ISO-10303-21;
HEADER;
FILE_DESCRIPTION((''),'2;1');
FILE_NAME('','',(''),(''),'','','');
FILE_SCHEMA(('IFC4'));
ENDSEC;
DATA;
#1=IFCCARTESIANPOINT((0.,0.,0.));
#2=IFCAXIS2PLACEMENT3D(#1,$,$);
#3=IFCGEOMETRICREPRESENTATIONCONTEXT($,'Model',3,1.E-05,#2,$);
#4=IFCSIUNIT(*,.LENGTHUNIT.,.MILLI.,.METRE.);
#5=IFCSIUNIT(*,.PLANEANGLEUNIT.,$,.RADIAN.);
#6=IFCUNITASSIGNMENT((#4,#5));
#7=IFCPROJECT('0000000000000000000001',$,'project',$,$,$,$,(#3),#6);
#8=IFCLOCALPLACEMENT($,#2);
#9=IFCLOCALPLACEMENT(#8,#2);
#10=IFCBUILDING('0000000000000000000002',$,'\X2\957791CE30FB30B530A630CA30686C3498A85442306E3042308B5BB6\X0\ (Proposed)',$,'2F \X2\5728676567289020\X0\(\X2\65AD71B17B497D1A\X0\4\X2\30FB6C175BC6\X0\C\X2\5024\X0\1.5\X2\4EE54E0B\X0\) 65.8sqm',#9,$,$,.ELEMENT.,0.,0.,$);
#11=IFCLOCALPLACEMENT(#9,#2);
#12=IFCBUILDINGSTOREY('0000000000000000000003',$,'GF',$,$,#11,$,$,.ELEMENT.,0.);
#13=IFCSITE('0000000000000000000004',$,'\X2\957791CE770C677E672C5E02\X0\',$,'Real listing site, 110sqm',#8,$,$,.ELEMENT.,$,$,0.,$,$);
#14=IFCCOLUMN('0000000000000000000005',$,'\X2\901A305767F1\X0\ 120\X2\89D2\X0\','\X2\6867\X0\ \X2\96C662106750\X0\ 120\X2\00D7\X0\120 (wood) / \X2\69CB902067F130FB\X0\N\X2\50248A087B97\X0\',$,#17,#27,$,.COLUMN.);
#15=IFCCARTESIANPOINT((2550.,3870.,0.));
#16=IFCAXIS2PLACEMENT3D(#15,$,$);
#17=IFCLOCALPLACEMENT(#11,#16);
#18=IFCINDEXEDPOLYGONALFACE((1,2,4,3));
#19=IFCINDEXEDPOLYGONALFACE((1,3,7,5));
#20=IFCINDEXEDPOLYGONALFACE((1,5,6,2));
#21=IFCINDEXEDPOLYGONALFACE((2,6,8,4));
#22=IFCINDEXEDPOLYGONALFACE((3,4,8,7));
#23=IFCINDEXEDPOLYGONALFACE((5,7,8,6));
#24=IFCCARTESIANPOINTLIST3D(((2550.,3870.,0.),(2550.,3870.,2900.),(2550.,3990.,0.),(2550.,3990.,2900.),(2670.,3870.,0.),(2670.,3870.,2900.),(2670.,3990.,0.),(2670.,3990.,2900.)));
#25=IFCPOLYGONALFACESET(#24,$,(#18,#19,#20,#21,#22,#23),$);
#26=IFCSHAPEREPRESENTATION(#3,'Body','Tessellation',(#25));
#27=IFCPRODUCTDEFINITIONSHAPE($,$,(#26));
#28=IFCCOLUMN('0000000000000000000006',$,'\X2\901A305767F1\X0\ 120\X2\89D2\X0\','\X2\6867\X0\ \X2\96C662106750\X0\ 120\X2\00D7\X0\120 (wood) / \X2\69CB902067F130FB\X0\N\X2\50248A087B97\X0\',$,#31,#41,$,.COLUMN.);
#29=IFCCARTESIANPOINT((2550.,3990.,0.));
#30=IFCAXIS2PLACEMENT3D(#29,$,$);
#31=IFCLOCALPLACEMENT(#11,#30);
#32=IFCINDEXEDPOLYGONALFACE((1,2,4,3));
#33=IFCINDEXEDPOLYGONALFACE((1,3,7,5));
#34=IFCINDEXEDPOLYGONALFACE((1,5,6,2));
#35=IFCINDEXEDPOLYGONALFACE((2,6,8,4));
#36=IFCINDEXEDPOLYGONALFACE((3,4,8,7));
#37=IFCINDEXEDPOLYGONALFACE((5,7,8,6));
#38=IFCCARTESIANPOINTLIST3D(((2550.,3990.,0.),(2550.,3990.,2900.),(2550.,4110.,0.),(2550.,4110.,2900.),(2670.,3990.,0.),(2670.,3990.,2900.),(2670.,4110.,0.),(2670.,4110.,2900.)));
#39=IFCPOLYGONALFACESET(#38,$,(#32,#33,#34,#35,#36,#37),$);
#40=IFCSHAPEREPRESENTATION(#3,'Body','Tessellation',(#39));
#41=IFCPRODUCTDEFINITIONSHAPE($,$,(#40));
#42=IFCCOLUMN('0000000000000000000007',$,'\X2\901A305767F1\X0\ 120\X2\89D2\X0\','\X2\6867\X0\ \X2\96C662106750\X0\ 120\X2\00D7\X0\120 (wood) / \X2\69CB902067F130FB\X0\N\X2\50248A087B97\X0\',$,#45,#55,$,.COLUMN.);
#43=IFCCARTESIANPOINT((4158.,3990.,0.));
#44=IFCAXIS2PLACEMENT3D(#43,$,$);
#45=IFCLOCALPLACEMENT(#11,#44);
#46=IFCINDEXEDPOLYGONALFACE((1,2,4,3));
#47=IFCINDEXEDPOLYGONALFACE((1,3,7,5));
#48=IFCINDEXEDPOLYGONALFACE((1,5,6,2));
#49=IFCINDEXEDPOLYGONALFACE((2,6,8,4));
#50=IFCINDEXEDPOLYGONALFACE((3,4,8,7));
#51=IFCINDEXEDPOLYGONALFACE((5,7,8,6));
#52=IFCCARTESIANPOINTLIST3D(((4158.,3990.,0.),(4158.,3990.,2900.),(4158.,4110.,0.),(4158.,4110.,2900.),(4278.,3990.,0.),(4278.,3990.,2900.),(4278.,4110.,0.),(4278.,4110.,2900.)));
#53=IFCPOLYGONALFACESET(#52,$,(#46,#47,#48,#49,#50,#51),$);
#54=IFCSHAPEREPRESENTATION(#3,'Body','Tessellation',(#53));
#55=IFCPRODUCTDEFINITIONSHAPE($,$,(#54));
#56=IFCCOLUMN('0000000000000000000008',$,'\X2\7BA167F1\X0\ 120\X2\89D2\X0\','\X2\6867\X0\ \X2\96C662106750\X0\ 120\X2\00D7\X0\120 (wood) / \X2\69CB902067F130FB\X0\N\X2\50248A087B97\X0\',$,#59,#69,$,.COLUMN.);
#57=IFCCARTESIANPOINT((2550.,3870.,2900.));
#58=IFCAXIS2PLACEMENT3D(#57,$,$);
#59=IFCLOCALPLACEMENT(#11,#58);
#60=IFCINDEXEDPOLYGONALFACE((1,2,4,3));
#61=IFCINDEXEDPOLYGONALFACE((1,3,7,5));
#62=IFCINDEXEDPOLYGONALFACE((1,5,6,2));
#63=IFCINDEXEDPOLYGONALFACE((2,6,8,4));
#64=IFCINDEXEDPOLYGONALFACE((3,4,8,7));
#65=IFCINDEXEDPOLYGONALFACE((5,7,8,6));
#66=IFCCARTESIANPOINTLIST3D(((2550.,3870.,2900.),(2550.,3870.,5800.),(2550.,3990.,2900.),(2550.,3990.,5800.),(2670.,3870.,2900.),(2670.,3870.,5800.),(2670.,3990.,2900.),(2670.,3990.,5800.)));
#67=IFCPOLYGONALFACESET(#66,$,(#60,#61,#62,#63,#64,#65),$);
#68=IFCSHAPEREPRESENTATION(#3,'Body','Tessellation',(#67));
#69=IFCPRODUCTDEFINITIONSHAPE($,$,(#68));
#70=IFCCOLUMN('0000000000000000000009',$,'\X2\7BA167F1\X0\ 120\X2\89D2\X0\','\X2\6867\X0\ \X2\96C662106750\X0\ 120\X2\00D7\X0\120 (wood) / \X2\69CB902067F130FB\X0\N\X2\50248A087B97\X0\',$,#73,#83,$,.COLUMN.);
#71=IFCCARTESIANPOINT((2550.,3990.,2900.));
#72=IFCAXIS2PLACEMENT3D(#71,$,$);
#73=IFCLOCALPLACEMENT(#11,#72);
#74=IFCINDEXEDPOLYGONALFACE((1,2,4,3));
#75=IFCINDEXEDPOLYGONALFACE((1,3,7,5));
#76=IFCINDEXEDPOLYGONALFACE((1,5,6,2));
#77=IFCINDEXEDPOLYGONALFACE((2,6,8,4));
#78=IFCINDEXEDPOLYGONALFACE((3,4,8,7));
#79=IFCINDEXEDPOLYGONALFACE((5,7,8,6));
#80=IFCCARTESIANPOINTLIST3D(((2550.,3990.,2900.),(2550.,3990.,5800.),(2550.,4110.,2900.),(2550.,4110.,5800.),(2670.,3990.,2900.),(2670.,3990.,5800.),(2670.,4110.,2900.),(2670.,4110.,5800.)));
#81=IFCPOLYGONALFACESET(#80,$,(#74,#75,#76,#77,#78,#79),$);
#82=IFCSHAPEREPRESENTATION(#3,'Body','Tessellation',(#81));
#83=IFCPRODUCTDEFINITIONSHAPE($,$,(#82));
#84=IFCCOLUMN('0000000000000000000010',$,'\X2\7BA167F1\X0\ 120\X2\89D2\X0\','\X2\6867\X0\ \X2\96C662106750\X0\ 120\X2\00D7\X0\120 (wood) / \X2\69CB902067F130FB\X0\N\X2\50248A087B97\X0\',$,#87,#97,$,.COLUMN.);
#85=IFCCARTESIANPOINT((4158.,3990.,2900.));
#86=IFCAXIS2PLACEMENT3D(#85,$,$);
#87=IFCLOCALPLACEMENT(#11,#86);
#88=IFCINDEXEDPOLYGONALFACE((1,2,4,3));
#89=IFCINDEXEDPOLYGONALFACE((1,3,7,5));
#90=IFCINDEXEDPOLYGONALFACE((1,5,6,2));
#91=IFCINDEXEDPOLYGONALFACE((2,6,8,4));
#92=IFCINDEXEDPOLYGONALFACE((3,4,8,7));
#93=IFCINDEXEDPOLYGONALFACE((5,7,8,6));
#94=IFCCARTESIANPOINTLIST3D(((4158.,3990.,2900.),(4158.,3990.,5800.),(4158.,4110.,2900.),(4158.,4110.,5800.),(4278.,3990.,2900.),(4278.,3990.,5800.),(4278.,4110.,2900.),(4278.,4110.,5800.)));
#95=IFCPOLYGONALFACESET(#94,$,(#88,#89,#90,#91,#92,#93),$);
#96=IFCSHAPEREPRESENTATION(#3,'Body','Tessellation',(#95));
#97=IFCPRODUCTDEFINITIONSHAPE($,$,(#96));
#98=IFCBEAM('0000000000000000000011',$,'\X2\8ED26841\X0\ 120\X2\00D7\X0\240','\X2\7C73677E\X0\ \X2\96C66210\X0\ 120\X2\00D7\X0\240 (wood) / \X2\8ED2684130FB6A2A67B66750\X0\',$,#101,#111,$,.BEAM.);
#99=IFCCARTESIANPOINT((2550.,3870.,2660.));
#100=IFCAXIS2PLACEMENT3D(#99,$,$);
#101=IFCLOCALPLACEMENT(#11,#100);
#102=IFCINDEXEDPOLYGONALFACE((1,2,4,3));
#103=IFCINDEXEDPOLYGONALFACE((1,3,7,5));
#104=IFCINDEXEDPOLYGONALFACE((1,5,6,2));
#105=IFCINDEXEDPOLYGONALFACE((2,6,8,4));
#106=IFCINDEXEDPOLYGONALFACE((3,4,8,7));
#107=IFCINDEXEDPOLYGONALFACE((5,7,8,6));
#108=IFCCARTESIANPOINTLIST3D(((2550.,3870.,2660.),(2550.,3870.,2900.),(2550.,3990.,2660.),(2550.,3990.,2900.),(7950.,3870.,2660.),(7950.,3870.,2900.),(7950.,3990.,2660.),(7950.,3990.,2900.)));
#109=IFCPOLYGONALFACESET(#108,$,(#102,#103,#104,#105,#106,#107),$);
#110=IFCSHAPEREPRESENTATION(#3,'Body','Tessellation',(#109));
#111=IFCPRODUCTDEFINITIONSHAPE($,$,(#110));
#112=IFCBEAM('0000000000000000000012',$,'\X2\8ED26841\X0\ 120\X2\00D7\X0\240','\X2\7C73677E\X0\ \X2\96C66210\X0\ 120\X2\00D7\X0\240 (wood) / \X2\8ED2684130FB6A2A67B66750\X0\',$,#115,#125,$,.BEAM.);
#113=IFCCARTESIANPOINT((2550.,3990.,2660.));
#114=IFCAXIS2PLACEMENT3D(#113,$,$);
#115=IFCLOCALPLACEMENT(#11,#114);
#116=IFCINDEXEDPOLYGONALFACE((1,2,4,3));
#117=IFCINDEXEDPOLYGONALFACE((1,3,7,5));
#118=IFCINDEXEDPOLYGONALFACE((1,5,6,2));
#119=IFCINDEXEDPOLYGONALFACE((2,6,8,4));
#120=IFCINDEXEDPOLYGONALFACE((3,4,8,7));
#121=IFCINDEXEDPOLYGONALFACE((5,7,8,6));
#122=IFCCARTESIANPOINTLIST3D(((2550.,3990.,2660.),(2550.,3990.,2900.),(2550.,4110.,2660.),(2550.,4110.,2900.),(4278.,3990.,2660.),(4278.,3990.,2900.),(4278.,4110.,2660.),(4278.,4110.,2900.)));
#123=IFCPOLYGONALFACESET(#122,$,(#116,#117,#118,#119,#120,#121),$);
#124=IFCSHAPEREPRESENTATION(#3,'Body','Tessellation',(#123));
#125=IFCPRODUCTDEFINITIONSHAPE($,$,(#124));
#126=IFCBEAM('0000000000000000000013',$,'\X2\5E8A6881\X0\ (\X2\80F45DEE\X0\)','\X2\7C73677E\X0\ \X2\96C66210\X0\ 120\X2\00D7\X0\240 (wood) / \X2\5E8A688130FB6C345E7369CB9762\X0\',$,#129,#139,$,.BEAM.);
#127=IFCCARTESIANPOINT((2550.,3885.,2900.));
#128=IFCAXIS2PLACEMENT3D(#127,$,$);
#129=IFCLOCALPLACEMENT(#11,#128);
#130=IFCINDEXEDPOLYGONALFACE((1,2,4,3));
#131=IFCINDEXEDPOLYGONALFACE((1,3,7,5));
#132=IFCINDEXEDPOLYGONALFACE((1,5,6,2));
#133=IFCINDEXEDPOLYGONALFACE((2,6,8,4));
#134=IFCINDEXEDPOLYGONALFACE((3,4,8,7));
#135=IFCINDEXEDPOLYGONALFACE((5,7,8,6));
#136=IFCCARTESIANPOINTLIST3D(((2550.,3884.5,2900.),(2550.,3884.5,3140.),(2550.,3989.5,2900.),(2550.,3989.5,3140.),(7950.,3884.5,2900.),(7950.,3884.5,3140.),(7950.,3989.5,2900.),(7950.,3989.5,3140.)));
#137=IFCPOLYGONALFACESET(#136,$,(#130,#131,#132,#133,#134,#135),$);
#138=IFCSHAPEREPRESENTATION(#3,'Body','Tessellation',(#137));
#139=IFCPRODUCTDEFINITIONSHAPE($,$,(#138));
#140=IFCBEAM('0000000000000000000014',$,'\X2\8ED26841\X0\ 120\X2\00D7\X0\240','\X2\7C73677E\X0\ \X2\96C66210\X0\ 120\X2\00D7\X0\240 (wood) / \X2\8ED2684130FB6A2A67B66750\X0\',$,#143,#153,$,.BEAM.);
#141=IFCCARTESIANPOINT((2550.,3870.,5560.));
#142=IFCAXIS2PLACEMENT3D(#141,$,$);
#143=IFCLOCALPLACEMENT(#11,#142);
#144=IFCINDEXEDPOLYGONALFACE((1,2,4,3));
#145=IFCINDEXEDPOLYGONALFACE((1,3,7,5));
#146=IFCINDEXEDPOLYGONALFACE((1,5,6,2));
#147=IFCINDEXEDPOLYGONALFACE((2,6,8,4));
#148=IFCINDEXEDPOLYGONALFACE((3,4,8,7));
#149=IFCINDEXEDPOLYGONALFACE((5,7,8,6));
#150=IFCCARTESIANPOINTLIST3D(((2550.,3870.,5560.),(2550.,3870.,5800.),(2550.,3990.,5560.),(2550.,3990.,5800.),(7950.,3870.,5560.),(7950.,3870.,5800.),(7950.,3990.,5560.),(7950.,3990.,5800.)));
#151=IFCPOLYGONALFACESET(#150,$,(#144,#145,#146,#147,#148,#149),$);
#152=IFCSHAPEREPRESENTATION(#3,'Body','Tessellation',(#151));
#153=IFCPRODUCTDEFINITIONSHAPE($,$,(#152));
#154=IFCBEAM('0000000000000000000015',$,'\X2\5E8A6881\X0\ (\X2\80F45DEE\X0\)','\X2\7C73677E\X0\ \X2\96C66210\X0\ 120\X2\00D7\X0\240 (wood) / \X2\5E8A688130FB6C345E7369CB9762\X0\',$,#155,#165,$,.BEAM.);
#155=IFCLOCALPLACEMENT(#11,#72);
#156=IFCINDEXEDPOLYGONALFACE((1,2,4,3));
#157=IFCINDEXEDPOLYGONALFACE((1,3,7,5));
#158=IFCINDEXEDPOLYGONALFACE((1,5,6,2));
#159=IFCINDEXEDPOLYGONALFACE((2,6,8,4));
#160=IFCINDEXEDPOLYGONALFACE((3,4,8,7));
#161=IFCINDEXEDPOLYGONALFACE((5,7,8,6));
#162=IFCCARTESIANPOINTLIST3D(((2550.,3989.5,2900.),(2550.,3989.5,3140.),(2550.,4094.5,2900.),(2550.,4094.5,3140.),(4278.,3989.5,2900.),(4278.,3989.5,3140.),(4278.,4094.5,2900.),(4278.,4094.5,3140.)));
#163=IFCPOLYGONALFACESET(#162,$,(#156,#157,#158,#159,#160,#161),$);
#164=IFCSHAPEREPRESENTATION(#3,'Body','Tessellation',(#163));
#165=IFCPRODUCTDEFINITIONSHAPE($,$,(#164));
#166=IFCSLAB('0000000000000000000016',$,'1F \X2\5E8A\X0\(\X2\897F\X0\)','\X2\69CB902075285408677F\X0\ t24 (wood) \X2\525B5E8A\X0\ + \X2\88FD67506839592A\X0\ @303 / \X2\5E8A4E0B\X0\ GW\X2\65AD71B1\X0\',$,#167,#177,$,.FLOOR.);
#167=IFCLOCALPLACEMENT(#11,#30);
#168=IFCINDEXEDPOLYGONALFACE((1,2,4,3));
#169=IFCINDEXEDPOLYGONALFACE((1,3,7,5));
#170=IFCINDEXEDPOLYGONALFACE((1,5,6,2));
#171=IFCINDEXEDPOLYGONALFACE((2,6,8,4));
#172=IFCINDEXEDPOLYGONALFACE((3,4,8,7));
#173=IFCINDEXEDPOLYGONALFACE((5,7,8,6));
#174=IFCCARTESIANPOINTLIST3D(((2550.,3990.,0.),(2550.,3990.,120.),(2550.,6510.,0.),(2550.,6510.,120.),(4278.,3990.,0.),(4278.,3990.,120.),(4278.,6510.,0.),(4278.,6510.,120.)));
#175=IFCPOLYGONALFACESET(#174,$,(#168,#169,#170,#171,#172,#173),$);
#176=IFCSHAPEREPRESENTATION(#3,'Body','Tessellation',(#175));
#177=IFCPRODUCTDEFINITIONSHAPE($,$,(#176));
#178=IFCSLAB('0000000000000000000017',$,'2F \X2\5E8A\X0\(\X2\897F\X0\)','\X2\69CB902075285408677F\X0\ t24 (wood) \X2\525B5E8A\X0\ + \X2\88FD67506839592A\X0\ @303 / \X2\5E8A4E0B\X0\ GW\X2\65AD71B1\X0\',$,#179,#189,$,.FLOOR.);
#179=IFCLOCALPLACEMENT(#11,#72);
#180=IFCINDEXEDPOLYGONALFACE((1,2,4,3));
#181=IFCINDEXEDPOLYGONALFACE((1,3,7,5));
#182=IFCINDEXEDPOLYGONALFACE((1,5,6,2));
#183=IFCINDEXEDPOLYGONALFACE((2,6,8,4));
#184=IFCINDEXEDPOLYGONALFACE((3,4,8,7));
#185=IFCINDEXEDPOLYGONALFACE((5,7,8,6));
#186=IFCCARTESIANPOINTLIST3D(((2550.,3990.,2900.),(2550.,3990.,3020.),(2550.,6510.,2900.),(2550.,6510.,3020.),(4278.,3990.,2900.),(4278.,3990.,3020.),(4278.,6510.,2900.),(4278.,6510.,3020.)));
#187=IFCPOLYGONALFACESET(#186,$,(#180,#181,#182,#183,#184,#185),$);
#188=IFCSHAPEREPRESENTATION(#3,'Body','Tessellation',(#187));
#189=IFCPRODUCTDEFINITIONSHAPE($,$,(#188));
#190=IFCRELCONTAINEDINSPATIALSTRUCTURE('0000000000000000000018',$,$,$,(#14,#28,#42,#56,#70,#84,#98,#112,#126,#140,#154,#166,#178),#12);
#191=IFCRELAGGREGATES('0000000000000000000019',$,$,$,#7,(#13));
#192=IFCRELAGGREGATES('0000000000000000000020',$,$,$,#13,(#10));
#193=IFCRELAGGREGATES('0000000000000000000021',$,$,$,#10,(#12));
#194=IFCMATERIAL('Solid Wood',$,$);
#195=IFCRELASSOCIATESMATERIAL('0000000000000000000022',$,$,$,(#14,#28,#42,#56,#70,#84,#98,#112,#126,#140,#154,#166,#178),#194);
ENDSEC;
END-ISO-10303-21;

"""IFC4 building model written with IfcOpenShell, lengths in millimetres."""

from ifc_helpers import new_model, si_unit, frame, frame_2d, origin, place, context, project, spatial, rectangle, extrude, material, element, save


model = new_model("IFC4")

# Units and contexts
model_context = context("Model", 3, precision=1e-05, world=origin())
ifc_project = project(units=[si_unit("LENGTHUNIT", "METRE", prefix="MILLI"), si_unit("PLANEANGLEUNIT", "RADIAN")], contexts=[model_context])

# Site, building, storey
site_placement = place(None, origin())
site = spatial("IfcSite", under=ifc_project, at=site_placement, Name="長野県松本市", ObjectType="Real listing site, 110sqm", CompositionType="ELEMENT", RefElevation=0.0)
building_placement = place(site_placement, origin())
building = spatial("IfcBuilding", under=site, at=building_placement, Name="長野・サウナと水風呂のある家 (Proposed)", ObjectType="2F 在来木造(断熱等級4・気密C値1.5以下) 65.8sqm", CompositionType="ELEMENT", ElevationOfRefHeight=0.0, ElevationOfTerrain=0.0)
storey_placement = place(building_placement, origin())
storey = spatial("IfcBuildingStorey", under=building, at=storey_placement, Name="GF", CompositionType="ELEMENT", Elevation=0.0)

# Columns
ifc_material_1 = material(Name="Solid Wood")
column_1_placement = place(storey_placement, frame((2550.0, 3870.0, 0.0)))
element("IfcColumn", 1, at=column_1_placement, inside=storey, material=ifc_material_1, Name="通し柱 120角", Description="桧 集成材 120×120 (wood) / 構造柱・N値計算", PredefinedType="COLUMN", context=model_context, shape_type="SweptSolid", body=[
    extrude(rectangle(XDim=120.0, YDim=120.0, at=frame_2d((60.0, 60.0))), frame((2550.0, 3870.0, 0.0)), (0.0, 0.0, 1.0), 2900.0),
])
column_2_placement = place(storey_placement, frame((2550.0, 3990.0, 0.0)))
element("IfcColumn", 2, at=column_2_placement, inside=storey, material=ifc_material_1, Name="通し柱 120角", Description="桧 集成材 120×120 (wood) / 構造柱・N値計算", PredefinedType="COLUMN", context=model_context, shape_type="SweptSolid", body=[
    extrude(rectangle(XDim=120.0, YDim=120.0, at=frame_2d((60.0, 60.0))), frame((2550.0, 3990.0, 0.0)), (0.0, 0.0, 1.0), 2900.0),
])
column_3_placement = place(storey_placement, frame((4158.0, 3990.0, 0.0)))
element("IfcColumn", 3, at=column_3_placement, inside=storey, material=ifc_material_1, Name="通し柱 120角", Description="桧 集成材 120×120 (wood) / 構造柱・N値計算", PredefinedType="COLUMN", context=model_context, shape_type="SweptSolid", body=[
    extrude(rectangle(XDim=120.0, YDim=120.0, at=frame_2d((60.0, 60.0))), frame((4158.0, 3990.0, 0.0)), (0.0, 0.0, 1.0), 2900.0),
])
column_4_placement = place(storey_placement, frame((2550.0, 3870.0, 2900.0)))
element("IfcColumn", 4, at=column_4_placement, inside=storey, material=ifc_material_1, Name="管柱 120角", Description="桧 集成材 120×120 (wood) / 構造柱・N値計算", PredefinedType="COLUMN", context=model_context, shape_type="SweptSolid", body=[
    extrude(rectangle(XDim=120.0, YDim=120.0, at=frame_2d((60.0, 60.0))), frame((2550.0, 3870.0, 2900.0)), (0.0, 0.0, 1.0), 2900.0),
])
column_5_placement = place(storey_placement, frame((2550.0, 3990.0, 2900.0)))
element("IfcColumn", 5, at=column_5_placement, inside=storey, material=ifc_material_1, Name="管柱 120角", Description="桧 集成材 120×120 (wood) / 構造柱・N値計算", PredefinedType="COLUMN", context=model_context, shape_type="SweptSolid", body=[
    extrude(rectangle(XDim=120.0, YDim=120.0, at=frame_2d((60.0, 60.0))), frame((2550.0, 3990.0, 2900.0)), (0.0, 0.0, 1.0), 2900.0),
])
column_6_placement = place(storey_placement, frame((4158.0, 3990.0, 2900.0)))
element("IfcColumn", 6, at=column_6_placement, inside=storey, material=ifc_material_1, Name="管柱 120角", Description="桧 集成材 120×120 (wood) / 構造柱・N値計算", PredefinedType="COLUMN", context=model_context, shape_type="SweptSolid", body=[
    extrude(rectangle(XDim=120.0, YDim=120.0, at=frame_2d((60.0, 60.0))), frame((4158.0, 3990.0, 2900.0)), (0.0, 0.0, 1.0), 2900.0),
])

# Beams
beam_1_placement = place(storey_placement, frame((2550.0, 3870.0, 2660.0)))
element("IfcBeam", 7, at=beam_1_placement, inside=storey, material=ifc_material_1, Name="軒桁 120×240", Description="米松 集成 120×240 (wood) / 軒桁・横架材", PredefinedType="BEAM", context=model_context, shape_type="SweptSolid", body=[
    extrude(rectangle(XDim=5400.0, YDim=120.0, at=frame_2d((2700.0, 60.0))), frame((2550.0, 3870.0, 2660.0)), (0.0, 0.0, 1.0), 240.0),
])
beam_2_placement = place(storey_placement, frame((2550.0, 3990.0, 2660.0)))
element("IfcBeam", 8, at=beam_2_placement, inside=storey, material=ifc_material_1, Name="軒桁 120×240", Description="米松 集成 120×240 (wood) / 軒桁・横架材", PredefinedType="BEAM", context=model_context, shape_type="SweptSolid", body=[
    extrude(rectangle(XDim=1728.0, YDim=120.0, at=frame_2d((864.0, 60.0))), frame((2550.0, 3990.0, 2660.0)), (0.0, 0.0, 1.0), 240.0),
])
beam_3_placement = place(storey_placement, frame((2550.0, 3885.0, 2900.0)))
element("IfcBeam", 9, at=beam_3_placement, inside=storey, material=ifc_material_1, Name="床梁 (胴差)", Description="米松 集成 120×240 (wood) / 床梁・水平構面", PredefinedType="BEAM", context=model_context, shape_type="SweptSolid", body=[
    extrude(rectangle(XDim=5400.0, YDim=105.0, at=frame_2d((2700.0, 52.0))), frame((2550.0, 3885.0, 2900.0)), (0.0, 0.0, 1.0), 240.0),
])
beam_4_placement = place(storey_placement, frame((2550.0, 3870.0, 5560.0)))
element("IfcBeam", 10, at=beam_4_placement, inside=storey, material=ifc_material_1, Name="軒桁 120×240", Description="米松 集成 120×240 (wood) / 軒桁・横架材", PredefinedType="BEAM", context=model_context, shape_type="SweptSolid", body=[
    extrude(rectangle(XDim=5400.0, YDim=120.0, at=frame_2d((2700.0, 60.0))), frame((2550.0, 3870.0, 5560.0)), (0.0, 0.0, 1.0), 240.0),
])
beam_5_placement = place(storey_placement, frame((2550.0, 3990.0, 2900.0)))
element("IfcBeam", 11, at=beam_5_placement, inside=storey, material=ifc_material_1, Name="床梁 (胴差)", Description="米松 集成 120×240 (wood) / 床梁・水平構面", PredefinedType="BEAM", context=model_context, shape_type="SweptSolid", body=[
    extrude(rectangle(XDim=1728.0, YDim=105.0, at=frame_2d((864.0, 52.0))), frame((2550.0, 3990.0, 2900.0)), (0.0, 0.0, 1.0), 240.0),
])

# Slabs
slab_1_placement = place(storey_placement, frame((2550.0, 3990.0, 0.0)))
element("IfcSlab", 12, at=slab_1_placement, inside=storey, material=ifc_material_1, Name="1F 床(西)", Description="構造用合板 t24 (wood) 剛床 + 製材根太 @303 / 床下 GW断熱", PredefinedType="FLOOR", context=model_context, shape_type="SweptSolid", body=[
    extrude(rectangle(XDim=1728.0, YDim=2520.0, at=frame_2d((864.0, 1260.0))), frame((2550.0, 3990.0, 0.0)), (0.0, 0.0, 1.0), 120.0),
])
slab_2_placement = place(storey_placement, frame((2550.0, 3990.0, 2900.0)))
element("IfcSlab", 13, at=slab_2_placement, inside=storey, material=ifc_material_1, Name="2F 床(西)", Description="構造用合板 t24 (wood) 剛床 + 製材根太 @303 / 床下 GW断熱", PredefinedType="FLOOR", context=model_context, shape_type="SweptSolid", body=[
    extrude(rectangle(XDim=1728.0, YDim=2520.0, at=frame_2d((864.0, 1260.0))), frame((2550.0, 3990.0, 2900.0)), (0.0, 0.0, 1.0), 120.0),
])

save(model, "model.ifc")
